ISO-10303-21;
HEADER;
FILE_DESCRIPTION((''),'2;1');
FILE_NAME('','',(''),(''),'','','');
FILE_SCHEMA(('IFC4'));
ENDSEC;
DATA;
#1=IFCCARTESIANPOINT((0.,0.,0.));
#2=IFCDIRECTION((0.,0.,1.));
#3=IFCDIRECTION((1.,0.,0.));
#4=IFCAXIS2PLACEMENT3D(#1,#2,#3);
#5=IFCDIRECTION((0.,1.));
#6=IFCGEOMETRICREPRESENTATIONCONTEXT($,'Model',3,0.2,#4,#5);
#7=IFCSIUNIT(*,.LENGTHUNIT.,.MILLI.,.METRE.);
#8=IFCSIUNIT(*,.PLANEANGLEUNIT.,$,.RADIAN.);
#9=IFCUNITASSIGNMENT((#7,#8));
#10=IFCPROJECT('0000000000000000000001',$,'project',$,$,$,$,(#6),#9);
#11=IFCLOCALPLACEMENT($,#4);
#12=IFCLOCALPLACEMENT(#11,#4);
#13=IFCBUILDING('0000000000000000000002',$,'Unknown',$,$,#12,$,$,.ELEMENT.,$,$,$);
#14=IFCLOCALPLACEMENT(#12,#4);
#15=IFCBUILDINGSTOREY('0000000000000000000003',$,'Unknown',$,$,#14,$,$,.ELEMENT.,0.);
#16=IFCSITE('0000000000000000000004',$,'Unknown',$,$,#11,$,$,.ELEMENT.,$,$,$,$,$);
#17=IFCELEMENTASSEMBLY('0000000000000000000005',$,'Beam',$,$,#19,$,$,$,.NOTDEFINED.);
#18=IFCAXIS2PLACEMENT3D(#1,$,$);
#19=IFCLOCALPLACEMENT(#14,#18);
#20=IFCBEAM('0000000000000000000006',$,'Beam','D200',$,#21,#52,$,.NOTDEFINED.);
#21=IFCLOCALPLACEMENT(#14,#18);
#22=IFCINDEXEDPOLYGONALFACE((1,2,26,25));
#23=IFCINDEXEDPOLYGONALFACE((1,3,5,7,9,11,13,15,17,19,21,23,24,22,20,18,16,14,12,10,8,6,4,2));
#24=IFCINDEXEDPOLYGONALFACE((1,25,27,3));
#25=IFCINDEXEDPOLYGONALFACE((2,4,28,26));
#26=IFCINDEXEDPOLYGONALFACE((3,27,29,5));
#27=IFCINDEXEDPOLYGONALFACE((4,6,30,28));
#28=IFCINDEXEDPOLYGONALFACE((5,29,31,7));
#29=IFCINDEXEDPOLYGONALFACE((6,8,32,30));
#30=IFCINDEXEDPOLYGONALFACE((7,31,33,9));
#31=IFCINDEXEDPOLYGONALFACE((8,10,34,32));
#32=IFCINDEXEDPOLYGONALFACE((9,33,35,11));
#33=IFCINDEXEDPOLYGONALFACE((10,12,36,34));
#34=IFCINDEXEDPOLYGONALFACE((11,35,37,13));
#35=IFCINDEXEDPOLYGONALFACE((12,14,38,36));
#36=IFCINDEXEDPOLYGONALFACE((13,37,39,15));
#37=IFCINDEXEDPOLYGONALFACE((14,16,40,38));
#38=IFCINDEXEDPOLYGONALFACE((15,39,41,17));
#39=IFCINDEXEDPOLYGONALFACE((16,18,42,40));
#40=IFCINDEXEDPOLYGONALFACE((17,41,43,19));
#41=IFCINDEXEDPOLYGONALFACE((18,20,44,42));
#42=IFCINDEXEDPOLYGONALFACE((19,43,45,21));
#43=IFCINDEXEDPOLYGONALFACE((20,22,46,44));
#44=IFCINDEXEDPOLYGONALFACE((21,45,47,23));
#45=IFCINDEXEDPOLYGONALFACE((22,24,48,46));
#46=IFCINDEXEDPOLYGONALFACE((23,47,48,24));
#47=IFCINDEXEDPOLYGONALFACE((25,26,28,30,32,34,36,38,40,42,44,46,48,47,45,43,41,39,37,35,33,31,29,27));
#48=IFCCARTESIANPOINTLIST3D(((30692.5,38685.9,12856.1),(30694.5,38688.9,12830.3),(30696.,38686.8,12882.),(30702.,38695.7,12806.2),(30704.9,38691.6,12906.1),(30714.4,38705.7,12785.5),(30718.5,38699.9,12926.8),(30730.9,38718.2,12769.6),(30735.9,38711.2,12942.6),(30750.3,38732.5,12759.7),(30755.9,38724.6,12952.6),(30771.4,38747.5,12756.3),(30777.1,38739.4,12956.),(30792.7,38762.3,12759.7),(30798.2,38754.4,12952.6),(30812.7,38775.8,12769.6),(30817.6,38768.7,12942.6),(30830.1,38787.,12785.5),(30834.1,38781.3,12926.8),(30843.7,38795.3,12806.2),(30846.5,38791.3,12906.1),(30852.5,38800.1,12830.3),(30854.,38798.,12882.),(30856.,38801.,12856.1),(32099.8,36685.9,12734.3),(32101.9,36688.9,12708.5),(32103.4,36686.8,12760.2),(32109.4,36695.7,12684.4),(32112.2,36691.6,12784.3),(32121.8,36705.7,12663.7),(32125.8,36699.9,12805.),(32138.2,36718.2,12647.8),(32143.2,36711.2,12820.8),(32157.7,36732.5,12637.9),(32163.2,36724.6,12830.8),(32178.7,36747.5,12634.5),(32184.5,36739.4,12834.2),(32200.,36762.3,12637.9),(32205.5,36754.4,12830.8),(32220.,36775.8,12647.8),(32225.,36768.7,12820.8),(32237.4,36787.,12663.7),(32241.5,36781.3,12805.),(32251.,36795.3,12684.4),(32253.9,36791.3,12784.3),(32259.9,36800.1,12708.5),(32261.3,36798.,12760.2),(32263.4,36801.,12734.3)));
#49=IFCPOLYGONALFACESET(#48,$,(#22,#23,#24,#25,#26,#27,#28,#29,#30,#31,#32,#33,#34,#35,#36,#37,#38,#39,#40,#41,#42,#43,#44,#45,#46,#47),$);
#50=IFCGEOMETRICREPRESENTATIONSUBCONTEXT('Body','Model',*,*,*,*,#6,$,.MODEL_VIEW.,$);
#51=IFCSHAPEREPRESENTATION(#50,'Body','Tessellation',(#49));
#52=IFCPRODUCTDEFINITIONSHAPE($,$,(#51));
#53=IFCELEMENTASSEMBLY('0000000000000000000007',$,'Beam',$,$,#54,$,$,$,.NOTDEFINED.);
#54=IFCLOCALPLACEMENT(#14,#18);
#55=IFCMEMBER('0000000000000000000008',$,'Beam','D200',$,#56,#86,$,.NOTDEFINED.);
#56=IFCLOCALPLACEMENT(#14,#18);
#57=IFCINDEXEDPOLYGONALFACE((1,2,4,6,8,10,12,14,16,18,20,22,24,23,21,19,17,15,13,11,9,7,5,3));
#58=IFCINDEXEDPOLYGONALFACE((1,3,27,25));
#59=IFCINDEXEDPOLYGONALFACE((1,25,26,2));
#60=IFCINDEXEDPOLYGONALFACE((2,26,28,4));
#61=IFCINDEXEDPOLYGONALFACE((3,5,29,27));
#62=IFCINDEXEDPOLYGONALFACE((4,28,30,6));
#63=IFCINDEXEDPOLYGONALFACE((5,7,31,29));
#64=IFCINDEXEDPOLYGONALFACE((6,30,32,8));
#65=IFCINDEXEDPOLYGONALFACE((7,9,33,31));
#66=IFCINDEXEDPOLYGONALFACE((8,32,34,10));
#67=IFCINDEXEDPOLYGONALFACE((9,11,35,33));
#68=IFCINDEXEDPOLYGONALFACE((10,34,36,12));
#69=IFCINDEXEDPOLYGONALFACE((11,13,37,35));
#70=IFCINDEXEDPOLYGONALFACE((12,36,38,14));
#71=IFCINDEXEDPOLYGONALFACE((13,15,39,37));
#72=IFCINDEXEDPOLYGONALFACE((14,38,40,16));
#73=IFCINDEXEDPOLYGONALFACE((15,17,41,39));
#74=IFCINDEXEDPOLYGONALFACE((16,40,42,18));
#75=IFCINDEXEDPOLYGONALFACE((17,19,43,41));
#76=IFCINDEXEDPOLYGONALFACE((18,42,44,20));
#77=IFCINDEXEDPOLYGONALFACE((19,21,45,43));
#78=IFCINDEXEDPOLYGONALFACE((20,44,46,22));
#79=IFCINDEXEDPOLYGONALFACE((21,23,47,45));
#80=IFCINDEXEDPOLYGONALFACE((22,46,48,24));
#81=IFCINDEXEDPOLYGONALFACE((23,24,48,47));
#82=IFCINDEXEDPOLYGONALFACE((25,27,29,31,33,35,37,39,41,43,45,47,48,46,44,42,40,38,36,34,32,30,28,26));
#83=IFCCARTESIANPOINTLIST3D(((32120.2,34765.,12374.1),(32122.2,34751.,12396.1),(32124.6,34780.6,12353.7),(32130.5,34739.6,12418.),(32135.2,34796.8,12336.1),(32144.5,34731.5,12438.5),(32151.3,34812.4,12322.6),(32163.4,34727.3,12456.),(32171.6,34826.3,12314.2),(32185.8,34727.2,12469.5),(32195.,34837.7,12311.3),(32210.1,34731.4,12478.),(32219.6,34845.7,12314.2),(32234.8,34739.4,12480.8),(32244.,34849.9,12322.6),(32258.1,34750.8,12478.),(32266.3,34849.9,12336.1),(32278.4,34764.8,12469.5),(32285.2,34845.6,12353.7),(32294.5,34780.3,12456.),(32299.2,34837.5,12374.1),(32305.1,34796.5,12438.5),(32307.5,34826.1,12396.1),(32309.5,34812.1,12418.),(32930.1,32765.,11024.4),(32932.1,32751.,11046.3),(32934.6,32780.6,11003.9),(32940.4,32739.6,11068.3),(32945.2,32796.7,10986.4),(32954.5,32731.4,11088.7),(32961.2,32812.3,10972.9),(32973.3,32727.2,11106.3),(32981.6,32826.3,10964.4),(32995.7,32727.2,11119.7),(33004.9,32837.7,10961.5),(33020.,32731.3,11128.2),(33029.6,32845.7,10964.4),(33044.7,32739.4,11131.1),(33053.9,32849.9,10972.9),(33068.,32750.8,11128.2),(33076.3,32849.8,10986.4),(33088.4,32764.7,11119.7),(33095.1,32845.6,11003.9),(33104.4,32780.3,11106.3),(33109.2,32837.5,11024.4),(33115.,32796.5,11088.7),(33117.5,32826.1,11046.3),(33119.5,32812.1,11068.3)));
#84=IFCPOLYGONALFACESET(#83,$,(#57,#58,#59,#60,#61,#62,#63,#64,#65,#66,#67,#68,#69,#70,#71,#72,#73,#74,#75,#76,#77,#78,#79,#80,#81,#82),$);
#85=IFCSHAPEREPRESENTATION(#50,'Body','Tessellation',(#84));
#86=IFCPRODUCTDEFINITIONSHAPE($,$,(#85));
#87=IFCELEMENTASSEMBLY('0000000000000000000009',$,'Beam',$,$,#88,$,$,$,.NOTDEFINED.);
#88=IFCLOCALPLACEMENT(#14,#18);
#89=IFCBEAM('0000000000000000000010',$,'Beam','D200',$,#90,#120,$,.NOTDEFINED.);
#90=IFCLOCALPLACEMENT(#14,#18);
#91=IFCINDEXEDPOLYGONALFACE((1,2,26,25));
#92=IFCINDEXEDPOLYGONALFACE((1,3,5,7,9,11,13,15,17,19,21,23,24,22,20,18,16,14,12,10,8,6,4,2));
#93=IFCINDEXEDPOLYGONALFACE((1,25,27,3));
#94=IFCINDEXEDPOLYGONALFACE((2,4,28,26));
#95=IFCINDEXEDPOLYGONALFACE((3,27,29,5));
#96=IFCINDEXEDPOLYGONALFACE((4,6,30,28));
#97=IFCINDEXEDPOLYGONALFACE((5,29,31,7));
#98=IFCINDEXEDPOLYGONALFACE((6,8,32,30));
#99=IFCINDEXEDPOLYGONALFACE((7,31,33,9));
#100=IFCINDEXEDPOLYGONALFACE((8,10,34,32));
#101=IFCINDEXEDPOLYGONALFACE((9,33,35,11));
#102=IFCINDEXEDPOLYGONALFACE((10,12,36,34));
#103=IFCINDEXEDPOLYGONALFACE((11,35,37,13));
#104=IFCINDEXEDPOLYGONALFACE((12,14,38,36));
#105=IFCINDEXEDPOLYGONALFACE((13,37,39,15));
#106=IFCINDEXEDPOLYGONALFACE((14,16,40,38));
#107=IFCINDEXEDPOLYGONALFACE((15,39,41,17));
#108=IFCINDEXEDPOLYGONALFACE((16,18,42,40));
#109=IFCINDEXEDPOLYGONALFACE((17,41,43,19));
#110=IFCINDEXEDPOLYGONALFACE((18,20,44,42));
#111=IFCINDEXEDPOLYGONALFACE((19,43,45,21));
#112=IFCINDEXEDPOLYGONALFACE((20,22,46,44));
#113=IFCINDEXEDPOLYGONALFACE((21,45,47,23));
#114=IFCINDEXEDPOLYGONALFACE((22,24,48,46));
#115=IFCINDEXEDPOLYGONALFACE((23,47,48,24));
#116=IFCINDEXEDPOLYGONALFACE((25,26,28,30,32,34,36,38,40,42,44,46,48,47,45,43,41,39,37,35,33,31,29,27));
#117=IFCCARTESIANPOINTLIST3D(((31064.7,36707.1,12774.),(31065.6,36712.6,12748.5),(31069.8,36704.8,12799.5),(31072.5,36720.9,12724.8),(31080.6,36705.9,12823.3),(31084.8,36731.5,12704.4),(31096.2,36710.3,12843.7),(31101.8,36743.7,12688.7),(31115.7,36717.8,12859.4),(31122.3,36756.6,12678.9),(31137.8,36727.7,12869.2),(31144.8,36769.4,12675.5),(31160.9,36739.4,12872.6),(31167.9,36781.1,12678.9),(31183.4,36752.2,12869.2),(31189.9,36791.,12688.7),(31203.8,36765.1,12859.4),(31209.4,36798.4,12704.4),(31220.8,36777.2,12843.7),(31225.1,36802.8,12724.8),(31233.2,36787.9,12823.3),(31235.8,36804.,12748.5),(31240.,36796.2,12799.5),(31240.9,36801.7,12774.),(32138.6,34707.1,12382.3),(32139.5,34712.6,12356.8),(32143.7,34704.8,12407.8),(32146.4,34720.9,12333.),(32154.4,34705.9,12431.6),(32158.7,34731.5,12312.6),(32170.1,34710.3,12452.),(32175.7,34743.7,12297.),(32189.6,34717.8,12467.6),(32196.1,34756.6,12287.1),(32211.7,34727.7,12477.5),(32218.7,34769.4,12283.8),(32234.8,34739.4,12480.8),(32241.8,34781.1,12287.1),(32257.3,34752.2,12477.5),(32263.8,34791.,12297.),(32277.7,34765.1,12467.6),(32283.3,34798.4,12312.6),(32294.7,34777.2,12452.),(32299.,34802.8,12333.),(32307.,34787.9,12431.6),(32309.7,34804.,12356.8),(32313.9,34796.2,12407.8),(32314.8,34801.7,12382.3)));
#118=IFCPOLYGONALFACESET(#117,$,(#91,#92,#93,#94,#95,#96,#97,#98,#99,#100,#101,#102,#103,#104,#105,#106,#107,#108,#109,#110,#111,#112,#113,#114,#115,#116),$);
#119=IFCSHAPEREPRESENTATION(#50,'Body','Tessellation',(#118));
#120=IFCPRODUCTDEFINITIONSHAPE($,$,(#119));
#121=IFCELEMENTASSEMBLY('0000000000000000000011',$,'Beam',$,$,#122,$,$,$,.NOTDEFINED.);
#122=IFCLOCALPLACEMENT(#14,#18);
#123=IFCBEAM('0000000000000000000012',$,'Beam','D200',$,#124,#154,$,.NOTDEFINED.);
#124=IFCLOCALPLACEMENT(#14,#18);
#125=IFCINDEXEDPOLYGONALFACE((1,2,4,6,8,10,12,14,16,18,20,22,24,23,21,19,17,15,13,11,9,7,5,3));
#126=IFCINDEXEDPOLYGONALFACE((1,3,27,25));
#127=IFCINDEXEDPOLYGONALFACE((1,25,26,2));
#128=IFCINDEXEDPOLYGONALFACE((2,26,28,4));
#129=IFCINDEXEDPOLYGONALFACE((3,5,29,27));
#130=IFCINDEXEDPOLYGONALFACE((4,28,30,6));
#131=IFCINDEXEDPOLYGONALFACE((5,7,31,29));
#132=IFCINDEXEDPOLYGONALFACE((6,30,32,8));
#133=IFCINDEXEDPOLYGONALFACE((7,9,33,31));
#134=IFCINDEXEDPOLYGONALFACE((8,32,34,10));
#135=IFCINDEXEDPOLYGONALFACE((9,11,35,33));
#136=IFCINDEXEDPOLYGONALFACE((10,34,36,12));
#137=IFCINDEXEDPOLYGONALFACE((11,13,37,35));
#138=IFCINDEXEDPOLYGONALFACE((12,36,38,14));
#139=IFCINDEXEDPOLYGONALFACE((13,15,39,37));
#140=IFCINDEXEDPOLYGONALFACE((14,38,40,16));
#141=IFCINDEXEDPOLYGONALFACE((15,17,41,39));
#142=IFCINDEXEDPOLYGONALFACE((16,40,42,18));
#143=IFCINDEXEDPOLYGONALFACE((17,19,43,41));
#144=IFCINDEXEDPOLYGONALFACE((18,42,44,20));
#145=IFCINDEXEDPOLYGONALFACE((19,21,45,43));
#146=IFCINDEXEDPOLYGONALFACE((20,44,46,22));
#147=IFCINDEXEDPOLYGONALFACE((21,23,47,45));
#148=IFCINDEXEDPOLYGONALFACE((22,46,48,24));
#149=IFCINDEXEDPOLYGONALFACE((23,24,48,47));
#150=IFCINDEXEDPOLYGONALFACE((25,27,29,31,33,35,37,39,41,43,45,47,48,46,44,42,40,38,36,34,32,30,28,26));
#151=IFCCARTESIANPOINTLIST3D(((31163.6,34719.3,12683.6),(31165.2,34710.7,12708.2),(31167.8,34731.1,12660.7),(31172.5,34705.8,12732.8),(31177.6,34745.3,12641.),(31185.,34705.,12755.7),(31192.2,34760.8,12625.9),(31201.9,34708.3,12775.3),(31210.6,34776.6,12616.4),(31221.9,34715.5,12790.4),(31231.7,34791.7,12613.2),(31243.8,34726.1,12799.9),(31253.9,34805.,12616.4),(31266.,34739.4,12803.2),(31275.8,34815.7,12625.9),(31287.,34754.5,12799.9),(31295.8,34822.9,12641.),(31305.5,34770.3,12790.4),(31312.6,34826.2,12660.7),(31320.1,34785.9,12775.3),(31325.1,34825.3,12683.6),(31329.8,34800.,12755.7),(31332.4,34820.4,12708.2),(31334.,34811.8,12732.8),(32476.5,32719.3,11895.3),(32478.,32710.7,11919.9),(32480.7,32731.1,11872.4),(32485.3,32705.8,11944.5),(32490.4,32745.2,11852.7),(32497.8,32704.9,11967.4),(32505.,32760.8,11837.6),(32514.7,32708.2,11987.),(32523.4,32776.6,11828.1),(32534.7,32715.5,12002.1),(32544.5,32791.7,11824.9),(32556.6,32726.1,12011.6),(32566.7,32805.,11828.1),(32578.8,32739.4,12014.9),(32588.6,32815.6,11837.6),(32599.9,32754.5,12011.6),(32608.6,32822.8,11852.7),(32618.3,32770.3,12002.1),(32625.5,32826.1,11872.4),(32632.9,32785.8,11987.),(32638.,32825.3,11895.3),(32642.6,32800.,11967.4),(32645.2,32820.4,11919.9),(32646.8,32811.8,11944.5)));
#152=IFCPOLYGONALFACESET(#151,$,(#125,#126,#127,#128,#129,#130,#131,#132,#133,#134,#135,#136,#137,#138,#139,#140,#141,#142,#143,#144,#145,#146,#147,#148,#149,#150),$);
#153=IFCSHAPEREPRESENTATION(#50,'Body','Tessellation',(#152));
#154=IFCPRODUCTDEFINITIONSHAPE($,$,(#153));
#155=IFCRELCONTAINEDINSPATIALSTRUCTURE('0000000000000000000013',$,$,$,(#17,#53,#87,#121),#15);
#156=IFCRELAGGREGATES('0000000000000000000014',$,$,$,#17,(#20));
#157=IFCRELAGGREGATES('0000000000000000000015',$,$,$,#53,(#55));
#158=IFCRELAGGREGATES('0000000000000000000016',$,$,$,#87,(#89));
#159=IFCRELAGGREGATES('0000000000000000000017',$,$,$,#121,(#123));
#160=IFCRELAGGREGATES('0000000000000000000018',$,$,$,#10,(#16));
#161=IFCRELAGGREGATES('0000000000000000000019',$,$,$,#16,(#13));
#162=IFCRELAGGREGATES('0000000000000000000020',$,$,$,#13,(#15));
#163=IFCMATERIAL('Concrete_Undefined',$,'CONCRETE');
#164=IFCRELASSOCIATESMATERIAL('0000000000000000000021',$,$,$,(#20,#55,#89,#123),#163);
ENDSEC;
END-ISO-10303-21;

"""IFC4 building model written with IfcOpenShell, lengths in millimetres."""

from ifc_helpers import new_model, si_unit, direction, frame, origin_with_axes, place, context, subcontext, project, spatial, line, indexed_curve, outline, extrude, material, element, aggregate, save


model = new_model("IFC4")

# Units and contexts
model_context = context("Model", 3, precision=0.2, world=origin_with_axes(), true_north=direction((0.0, 1.0)))
body_context = subcontext(model_context, "Body", "Model", "MODEL_VIEW")
ifc_project = project(units=[si_unit("LENGTHUNIT", "METRE", prefix="MILLI"), si_unit("PLANEANGLEUNIT", "RADIAN")], contexts=[model_context])

# Site, building, storey
site_placement = place(None, origin_with_axes())
site = spatial("IfcSite", under=ifc_project, at=site_placement, Name="Unknown", CompositionType="ELEMENT")
building_placement = place(site_placement, origin_with_axes())
building = spatial("IfcBuilding", under=site, at=building_placement, Name="Unknown", CompositionType="ELEMENT")
storey_placement = place(building_placement, origin_with_axes())
storey = spatial("IfcBuildingStorey", under=building, at=storey_placement, Name="Unknown", CompositionType="ELEMENT", Elevation=0.0)

# Shared definitions
ifc_material = material(Name="Concrete_Undefined", Category="CONCRETE")

# Element assembly, beam
assembly_1_placement = place(storey_placement, frame((30774.3, 38743.5, 12856.1), z_axis=(-0.817818, -0.575477, 0.0), x_axis=(0.574765, -0.816806, -0.049742)))
assembly_1 = element("IfcElementAssembly", 1, at=assembly_1_placement, inside=storey, Name="Beam", PredefinedType="NOTDEFINED")
beam_1_placement = place(assembly_1_placement, origin_with_axes())
beam_1 = element("IfcBeam", 2, at=beam_1_placement, material=ifc_material, Name="Beam", Description="D200", PredefinedType="NOTDEFINED", context=body_context, shape_type="SolidModel", body=[
    extrude(outline(indexed_curve([(100.0, 0.0), (96.6, 25.9), (86.6, 50.0), (70.7, 70.7), (50.0, 86.6), (25.9, 96.6), (0.0, 100.0), (-25.9, 96.6), (-50.0, 86.6), (-70.7, 70.7), (-86.6, 50.0), (-96.6, 25.9), (-100.0, 0.0), (-96.6, -25.9), (-86.6, -50.0), (-70.7, -70.7), (-50.0, -86.6), (-25.9, -96.6), (0.0, -100.0), (25.9, -96.6), (50.0, -86.6), (70.7, -70.7), (86.6, -50.0), (96.6, -25.9)], segments=[line(1, 2, 3, 4, 5, 6, 7, 8, 9, 10, 11, 12, 13, 14, 15, 16, 17, 18, 19, 20, 21, 22, 23, 24, 1)])), frame((0.0, 0.0, 0.0), z_axis=(-1.0, 0.0, 0.0), x_axis=(0.0, 0.0, 1.0)), (0.0, 0.0, -1.0), 2448.6),
])
aggregate(assembly_1, [beam_1])

# Element assembly, member
assembly_2_placement = place(storey_placement, frame((32214.9, 34788.6, 12396.1), z_axis=(-0.926882, -0.375354, 0.0), x_axis=(0.318225, -0.78581, -0.530316)))
assembly_2 = element("IfcElementAssembly", 3, at=assembly_2_placement, inside=storey, Name="Beam", PredefinedType="NOTDEFINED")
member_1_placement = place(assembly_2_placement, origin_with_axes())
member_1 = element("IfcMember", 4, at=member_1_placement, material=ifc_material, Name="Beam", Description="D200", PredefinedType="NOTDEFINED", context=body_context, shape_type="SolidModel", body=[
    extrude(outline(indexed_curve([(100.0, 0.0), (96.6, 25.9), (86.6, 50.0), (70.7, 70.7), (50.0, 86.6), (25.9, 96.6), (0.0, 100.0), (-25.9, 96.6), (-50.0, 86.6), (-70.7, 70.7), (-86.6, 50.0), (-96.6, 25.9), (-100.0, 0.0), (-96.6, -25.9), (-86.6, -50.0), (-70.7, -70.7), (-50.0, -86.6), (-25.9, -96.6), (0.0, -100.0), (25.9, -96.6), (50.0, -86.6), (70.7, -70.7), (86.6, -50.0), (96.6, -25.9)], segments=[line(1, 2, 3, 4, 5, 6, 7, 8, 9, 10, 11, 12, 13, 14, 15, 16, 17, 18, 19, 20, 21, 22, 23, 24, 1)])), frame((0.0, 0.0, 0.0), z_axis=(-1.0, 0.0, 0.0), x_axis=(0.0, 0.0, 1.0)), (0.0, 0.0, -1.0), 2545.2),
])
aggregate(assembly_2, [member_1])

# Element assemblies, beams
assembly_3_placement = place(storey_placement, frame((31152.8, 36754.4, 12774.0), z_axis=(-0.881028, -0.473065, 0.0), x_axis=(0.466174, -0.868195, -0.170053)))
assembly_3 = element("IfcElementAssembly", 5, at=assembly_3_placement, inside=storey, Name="Beam", PredefinedType="NOTDEFINED")
beam_2_placement = place(assembly_3_placement, origin_with_axes())
beam_2 = element("IfcBeam", 6, at=beam_2_placement, material=ifc_material, Name="Beam", Description="D200", PredefinedType="NOTDEFINED", context=body_context, shape_type="SolidModel", body=[
    extrude(outline(indexed_curve([(100.0, 0.0), (96.6, 25.9), (86.6, 50.0), (70.7, 70.7), (50.0, 86.6), (25.9, 96.6), (0.0, 100.0), (-25.9, 96.6), (-50.0, 86.6), (-70.7, 70.7), (-86.6, 50.0), (-96.6, 25.9), (-100.0, 0.0), (-96.6, -25.9), (-86.6, -50.0), (-70.7, -70.7), (-50.0, -86.6), (-25.9, -96.6), (0.0, -100.0), (25.9, -96.6), (50.0, -86.6), (70.7, -70.7), (86.6, -50.0), (96.6, -25.9)], segments=[line(1, 2, 3, 4, 5, 6, 7, 8, 9, 10, 11, 12, 13, 14, 15, 16, 17, 18, 19, 20, 21, 22, 23, 24, 1)])), frame((0.0, 0.0, 0.0), z_axis=(-1.0, 0.0, 0.0), x_axis=(0.0, 0.0, 1.0)), (0.0, 0.0, -1.0), 2303.6),
])
aggregate(assembly_3, [beam_2])
assembly_4_placement = place(storey_placement, frame((31248.8, 34765.6, 12708.2), z_axis=(-0.835989, -0.548747, 0.0), x_axis=(0.521184, -0.793998, -0.312945)))
assembly_4 = element("IfcElementAssembly", 7, at=assembly_4_placement, inside=storey, Name="Beam", PredefinedType="NOTDEFINED")
beam_3_placement = place(assembly_4_placement, origin_with_axes())
beam_3 = element("IfcBeam", 8, at=beam_3_placement, material=ifc_material, Name="Beam", Description="D200", PredefinedType="NOTDEFINED", context=body_context, shape_type="SolidModel", body=[
    extrude(outline(indexed_curve([(100.0, 0.0), (96.6, 25.9), (86.6, 50.0), (70.7, 70.7), (50.0, 86.6), (25.9, 96.6), (0.0, 100.0), (-25.9, 96.6), (-50.0, 86.6), (-70.7, 70.7), (-86.6, 50.0), (-96.6, 25.9), (-100.0, 0.0), (-96.6, -25.9), (-86.6, -50.0), (-70.7, -70.7), (-50.0, -86.6), (-25.9, -96.6), (0.0, -100.0), (25.9, -96.6), (50.0, -86.6), (70.7, -70.7), (86.6, -50.0), (96.6, -25.9)], segments=[line(1, 2, 3, 4, 5, 6, 7, 8, 9, 10, 11, 12, 13, 14, 15, 16, 17, 18, 19, 20, 21, 22, 23, 24, 1)])), frame((0.0, 0.0, 0.0), z_axis=(-1.0, 0.0, 0.0), x_axis=(0.0, 0.0, 1.0)), (0.0, 0.0, -1.0), 2518.9),
])
aggregate(assembly_4, [beam_3])

save(model, "model.ifc")
